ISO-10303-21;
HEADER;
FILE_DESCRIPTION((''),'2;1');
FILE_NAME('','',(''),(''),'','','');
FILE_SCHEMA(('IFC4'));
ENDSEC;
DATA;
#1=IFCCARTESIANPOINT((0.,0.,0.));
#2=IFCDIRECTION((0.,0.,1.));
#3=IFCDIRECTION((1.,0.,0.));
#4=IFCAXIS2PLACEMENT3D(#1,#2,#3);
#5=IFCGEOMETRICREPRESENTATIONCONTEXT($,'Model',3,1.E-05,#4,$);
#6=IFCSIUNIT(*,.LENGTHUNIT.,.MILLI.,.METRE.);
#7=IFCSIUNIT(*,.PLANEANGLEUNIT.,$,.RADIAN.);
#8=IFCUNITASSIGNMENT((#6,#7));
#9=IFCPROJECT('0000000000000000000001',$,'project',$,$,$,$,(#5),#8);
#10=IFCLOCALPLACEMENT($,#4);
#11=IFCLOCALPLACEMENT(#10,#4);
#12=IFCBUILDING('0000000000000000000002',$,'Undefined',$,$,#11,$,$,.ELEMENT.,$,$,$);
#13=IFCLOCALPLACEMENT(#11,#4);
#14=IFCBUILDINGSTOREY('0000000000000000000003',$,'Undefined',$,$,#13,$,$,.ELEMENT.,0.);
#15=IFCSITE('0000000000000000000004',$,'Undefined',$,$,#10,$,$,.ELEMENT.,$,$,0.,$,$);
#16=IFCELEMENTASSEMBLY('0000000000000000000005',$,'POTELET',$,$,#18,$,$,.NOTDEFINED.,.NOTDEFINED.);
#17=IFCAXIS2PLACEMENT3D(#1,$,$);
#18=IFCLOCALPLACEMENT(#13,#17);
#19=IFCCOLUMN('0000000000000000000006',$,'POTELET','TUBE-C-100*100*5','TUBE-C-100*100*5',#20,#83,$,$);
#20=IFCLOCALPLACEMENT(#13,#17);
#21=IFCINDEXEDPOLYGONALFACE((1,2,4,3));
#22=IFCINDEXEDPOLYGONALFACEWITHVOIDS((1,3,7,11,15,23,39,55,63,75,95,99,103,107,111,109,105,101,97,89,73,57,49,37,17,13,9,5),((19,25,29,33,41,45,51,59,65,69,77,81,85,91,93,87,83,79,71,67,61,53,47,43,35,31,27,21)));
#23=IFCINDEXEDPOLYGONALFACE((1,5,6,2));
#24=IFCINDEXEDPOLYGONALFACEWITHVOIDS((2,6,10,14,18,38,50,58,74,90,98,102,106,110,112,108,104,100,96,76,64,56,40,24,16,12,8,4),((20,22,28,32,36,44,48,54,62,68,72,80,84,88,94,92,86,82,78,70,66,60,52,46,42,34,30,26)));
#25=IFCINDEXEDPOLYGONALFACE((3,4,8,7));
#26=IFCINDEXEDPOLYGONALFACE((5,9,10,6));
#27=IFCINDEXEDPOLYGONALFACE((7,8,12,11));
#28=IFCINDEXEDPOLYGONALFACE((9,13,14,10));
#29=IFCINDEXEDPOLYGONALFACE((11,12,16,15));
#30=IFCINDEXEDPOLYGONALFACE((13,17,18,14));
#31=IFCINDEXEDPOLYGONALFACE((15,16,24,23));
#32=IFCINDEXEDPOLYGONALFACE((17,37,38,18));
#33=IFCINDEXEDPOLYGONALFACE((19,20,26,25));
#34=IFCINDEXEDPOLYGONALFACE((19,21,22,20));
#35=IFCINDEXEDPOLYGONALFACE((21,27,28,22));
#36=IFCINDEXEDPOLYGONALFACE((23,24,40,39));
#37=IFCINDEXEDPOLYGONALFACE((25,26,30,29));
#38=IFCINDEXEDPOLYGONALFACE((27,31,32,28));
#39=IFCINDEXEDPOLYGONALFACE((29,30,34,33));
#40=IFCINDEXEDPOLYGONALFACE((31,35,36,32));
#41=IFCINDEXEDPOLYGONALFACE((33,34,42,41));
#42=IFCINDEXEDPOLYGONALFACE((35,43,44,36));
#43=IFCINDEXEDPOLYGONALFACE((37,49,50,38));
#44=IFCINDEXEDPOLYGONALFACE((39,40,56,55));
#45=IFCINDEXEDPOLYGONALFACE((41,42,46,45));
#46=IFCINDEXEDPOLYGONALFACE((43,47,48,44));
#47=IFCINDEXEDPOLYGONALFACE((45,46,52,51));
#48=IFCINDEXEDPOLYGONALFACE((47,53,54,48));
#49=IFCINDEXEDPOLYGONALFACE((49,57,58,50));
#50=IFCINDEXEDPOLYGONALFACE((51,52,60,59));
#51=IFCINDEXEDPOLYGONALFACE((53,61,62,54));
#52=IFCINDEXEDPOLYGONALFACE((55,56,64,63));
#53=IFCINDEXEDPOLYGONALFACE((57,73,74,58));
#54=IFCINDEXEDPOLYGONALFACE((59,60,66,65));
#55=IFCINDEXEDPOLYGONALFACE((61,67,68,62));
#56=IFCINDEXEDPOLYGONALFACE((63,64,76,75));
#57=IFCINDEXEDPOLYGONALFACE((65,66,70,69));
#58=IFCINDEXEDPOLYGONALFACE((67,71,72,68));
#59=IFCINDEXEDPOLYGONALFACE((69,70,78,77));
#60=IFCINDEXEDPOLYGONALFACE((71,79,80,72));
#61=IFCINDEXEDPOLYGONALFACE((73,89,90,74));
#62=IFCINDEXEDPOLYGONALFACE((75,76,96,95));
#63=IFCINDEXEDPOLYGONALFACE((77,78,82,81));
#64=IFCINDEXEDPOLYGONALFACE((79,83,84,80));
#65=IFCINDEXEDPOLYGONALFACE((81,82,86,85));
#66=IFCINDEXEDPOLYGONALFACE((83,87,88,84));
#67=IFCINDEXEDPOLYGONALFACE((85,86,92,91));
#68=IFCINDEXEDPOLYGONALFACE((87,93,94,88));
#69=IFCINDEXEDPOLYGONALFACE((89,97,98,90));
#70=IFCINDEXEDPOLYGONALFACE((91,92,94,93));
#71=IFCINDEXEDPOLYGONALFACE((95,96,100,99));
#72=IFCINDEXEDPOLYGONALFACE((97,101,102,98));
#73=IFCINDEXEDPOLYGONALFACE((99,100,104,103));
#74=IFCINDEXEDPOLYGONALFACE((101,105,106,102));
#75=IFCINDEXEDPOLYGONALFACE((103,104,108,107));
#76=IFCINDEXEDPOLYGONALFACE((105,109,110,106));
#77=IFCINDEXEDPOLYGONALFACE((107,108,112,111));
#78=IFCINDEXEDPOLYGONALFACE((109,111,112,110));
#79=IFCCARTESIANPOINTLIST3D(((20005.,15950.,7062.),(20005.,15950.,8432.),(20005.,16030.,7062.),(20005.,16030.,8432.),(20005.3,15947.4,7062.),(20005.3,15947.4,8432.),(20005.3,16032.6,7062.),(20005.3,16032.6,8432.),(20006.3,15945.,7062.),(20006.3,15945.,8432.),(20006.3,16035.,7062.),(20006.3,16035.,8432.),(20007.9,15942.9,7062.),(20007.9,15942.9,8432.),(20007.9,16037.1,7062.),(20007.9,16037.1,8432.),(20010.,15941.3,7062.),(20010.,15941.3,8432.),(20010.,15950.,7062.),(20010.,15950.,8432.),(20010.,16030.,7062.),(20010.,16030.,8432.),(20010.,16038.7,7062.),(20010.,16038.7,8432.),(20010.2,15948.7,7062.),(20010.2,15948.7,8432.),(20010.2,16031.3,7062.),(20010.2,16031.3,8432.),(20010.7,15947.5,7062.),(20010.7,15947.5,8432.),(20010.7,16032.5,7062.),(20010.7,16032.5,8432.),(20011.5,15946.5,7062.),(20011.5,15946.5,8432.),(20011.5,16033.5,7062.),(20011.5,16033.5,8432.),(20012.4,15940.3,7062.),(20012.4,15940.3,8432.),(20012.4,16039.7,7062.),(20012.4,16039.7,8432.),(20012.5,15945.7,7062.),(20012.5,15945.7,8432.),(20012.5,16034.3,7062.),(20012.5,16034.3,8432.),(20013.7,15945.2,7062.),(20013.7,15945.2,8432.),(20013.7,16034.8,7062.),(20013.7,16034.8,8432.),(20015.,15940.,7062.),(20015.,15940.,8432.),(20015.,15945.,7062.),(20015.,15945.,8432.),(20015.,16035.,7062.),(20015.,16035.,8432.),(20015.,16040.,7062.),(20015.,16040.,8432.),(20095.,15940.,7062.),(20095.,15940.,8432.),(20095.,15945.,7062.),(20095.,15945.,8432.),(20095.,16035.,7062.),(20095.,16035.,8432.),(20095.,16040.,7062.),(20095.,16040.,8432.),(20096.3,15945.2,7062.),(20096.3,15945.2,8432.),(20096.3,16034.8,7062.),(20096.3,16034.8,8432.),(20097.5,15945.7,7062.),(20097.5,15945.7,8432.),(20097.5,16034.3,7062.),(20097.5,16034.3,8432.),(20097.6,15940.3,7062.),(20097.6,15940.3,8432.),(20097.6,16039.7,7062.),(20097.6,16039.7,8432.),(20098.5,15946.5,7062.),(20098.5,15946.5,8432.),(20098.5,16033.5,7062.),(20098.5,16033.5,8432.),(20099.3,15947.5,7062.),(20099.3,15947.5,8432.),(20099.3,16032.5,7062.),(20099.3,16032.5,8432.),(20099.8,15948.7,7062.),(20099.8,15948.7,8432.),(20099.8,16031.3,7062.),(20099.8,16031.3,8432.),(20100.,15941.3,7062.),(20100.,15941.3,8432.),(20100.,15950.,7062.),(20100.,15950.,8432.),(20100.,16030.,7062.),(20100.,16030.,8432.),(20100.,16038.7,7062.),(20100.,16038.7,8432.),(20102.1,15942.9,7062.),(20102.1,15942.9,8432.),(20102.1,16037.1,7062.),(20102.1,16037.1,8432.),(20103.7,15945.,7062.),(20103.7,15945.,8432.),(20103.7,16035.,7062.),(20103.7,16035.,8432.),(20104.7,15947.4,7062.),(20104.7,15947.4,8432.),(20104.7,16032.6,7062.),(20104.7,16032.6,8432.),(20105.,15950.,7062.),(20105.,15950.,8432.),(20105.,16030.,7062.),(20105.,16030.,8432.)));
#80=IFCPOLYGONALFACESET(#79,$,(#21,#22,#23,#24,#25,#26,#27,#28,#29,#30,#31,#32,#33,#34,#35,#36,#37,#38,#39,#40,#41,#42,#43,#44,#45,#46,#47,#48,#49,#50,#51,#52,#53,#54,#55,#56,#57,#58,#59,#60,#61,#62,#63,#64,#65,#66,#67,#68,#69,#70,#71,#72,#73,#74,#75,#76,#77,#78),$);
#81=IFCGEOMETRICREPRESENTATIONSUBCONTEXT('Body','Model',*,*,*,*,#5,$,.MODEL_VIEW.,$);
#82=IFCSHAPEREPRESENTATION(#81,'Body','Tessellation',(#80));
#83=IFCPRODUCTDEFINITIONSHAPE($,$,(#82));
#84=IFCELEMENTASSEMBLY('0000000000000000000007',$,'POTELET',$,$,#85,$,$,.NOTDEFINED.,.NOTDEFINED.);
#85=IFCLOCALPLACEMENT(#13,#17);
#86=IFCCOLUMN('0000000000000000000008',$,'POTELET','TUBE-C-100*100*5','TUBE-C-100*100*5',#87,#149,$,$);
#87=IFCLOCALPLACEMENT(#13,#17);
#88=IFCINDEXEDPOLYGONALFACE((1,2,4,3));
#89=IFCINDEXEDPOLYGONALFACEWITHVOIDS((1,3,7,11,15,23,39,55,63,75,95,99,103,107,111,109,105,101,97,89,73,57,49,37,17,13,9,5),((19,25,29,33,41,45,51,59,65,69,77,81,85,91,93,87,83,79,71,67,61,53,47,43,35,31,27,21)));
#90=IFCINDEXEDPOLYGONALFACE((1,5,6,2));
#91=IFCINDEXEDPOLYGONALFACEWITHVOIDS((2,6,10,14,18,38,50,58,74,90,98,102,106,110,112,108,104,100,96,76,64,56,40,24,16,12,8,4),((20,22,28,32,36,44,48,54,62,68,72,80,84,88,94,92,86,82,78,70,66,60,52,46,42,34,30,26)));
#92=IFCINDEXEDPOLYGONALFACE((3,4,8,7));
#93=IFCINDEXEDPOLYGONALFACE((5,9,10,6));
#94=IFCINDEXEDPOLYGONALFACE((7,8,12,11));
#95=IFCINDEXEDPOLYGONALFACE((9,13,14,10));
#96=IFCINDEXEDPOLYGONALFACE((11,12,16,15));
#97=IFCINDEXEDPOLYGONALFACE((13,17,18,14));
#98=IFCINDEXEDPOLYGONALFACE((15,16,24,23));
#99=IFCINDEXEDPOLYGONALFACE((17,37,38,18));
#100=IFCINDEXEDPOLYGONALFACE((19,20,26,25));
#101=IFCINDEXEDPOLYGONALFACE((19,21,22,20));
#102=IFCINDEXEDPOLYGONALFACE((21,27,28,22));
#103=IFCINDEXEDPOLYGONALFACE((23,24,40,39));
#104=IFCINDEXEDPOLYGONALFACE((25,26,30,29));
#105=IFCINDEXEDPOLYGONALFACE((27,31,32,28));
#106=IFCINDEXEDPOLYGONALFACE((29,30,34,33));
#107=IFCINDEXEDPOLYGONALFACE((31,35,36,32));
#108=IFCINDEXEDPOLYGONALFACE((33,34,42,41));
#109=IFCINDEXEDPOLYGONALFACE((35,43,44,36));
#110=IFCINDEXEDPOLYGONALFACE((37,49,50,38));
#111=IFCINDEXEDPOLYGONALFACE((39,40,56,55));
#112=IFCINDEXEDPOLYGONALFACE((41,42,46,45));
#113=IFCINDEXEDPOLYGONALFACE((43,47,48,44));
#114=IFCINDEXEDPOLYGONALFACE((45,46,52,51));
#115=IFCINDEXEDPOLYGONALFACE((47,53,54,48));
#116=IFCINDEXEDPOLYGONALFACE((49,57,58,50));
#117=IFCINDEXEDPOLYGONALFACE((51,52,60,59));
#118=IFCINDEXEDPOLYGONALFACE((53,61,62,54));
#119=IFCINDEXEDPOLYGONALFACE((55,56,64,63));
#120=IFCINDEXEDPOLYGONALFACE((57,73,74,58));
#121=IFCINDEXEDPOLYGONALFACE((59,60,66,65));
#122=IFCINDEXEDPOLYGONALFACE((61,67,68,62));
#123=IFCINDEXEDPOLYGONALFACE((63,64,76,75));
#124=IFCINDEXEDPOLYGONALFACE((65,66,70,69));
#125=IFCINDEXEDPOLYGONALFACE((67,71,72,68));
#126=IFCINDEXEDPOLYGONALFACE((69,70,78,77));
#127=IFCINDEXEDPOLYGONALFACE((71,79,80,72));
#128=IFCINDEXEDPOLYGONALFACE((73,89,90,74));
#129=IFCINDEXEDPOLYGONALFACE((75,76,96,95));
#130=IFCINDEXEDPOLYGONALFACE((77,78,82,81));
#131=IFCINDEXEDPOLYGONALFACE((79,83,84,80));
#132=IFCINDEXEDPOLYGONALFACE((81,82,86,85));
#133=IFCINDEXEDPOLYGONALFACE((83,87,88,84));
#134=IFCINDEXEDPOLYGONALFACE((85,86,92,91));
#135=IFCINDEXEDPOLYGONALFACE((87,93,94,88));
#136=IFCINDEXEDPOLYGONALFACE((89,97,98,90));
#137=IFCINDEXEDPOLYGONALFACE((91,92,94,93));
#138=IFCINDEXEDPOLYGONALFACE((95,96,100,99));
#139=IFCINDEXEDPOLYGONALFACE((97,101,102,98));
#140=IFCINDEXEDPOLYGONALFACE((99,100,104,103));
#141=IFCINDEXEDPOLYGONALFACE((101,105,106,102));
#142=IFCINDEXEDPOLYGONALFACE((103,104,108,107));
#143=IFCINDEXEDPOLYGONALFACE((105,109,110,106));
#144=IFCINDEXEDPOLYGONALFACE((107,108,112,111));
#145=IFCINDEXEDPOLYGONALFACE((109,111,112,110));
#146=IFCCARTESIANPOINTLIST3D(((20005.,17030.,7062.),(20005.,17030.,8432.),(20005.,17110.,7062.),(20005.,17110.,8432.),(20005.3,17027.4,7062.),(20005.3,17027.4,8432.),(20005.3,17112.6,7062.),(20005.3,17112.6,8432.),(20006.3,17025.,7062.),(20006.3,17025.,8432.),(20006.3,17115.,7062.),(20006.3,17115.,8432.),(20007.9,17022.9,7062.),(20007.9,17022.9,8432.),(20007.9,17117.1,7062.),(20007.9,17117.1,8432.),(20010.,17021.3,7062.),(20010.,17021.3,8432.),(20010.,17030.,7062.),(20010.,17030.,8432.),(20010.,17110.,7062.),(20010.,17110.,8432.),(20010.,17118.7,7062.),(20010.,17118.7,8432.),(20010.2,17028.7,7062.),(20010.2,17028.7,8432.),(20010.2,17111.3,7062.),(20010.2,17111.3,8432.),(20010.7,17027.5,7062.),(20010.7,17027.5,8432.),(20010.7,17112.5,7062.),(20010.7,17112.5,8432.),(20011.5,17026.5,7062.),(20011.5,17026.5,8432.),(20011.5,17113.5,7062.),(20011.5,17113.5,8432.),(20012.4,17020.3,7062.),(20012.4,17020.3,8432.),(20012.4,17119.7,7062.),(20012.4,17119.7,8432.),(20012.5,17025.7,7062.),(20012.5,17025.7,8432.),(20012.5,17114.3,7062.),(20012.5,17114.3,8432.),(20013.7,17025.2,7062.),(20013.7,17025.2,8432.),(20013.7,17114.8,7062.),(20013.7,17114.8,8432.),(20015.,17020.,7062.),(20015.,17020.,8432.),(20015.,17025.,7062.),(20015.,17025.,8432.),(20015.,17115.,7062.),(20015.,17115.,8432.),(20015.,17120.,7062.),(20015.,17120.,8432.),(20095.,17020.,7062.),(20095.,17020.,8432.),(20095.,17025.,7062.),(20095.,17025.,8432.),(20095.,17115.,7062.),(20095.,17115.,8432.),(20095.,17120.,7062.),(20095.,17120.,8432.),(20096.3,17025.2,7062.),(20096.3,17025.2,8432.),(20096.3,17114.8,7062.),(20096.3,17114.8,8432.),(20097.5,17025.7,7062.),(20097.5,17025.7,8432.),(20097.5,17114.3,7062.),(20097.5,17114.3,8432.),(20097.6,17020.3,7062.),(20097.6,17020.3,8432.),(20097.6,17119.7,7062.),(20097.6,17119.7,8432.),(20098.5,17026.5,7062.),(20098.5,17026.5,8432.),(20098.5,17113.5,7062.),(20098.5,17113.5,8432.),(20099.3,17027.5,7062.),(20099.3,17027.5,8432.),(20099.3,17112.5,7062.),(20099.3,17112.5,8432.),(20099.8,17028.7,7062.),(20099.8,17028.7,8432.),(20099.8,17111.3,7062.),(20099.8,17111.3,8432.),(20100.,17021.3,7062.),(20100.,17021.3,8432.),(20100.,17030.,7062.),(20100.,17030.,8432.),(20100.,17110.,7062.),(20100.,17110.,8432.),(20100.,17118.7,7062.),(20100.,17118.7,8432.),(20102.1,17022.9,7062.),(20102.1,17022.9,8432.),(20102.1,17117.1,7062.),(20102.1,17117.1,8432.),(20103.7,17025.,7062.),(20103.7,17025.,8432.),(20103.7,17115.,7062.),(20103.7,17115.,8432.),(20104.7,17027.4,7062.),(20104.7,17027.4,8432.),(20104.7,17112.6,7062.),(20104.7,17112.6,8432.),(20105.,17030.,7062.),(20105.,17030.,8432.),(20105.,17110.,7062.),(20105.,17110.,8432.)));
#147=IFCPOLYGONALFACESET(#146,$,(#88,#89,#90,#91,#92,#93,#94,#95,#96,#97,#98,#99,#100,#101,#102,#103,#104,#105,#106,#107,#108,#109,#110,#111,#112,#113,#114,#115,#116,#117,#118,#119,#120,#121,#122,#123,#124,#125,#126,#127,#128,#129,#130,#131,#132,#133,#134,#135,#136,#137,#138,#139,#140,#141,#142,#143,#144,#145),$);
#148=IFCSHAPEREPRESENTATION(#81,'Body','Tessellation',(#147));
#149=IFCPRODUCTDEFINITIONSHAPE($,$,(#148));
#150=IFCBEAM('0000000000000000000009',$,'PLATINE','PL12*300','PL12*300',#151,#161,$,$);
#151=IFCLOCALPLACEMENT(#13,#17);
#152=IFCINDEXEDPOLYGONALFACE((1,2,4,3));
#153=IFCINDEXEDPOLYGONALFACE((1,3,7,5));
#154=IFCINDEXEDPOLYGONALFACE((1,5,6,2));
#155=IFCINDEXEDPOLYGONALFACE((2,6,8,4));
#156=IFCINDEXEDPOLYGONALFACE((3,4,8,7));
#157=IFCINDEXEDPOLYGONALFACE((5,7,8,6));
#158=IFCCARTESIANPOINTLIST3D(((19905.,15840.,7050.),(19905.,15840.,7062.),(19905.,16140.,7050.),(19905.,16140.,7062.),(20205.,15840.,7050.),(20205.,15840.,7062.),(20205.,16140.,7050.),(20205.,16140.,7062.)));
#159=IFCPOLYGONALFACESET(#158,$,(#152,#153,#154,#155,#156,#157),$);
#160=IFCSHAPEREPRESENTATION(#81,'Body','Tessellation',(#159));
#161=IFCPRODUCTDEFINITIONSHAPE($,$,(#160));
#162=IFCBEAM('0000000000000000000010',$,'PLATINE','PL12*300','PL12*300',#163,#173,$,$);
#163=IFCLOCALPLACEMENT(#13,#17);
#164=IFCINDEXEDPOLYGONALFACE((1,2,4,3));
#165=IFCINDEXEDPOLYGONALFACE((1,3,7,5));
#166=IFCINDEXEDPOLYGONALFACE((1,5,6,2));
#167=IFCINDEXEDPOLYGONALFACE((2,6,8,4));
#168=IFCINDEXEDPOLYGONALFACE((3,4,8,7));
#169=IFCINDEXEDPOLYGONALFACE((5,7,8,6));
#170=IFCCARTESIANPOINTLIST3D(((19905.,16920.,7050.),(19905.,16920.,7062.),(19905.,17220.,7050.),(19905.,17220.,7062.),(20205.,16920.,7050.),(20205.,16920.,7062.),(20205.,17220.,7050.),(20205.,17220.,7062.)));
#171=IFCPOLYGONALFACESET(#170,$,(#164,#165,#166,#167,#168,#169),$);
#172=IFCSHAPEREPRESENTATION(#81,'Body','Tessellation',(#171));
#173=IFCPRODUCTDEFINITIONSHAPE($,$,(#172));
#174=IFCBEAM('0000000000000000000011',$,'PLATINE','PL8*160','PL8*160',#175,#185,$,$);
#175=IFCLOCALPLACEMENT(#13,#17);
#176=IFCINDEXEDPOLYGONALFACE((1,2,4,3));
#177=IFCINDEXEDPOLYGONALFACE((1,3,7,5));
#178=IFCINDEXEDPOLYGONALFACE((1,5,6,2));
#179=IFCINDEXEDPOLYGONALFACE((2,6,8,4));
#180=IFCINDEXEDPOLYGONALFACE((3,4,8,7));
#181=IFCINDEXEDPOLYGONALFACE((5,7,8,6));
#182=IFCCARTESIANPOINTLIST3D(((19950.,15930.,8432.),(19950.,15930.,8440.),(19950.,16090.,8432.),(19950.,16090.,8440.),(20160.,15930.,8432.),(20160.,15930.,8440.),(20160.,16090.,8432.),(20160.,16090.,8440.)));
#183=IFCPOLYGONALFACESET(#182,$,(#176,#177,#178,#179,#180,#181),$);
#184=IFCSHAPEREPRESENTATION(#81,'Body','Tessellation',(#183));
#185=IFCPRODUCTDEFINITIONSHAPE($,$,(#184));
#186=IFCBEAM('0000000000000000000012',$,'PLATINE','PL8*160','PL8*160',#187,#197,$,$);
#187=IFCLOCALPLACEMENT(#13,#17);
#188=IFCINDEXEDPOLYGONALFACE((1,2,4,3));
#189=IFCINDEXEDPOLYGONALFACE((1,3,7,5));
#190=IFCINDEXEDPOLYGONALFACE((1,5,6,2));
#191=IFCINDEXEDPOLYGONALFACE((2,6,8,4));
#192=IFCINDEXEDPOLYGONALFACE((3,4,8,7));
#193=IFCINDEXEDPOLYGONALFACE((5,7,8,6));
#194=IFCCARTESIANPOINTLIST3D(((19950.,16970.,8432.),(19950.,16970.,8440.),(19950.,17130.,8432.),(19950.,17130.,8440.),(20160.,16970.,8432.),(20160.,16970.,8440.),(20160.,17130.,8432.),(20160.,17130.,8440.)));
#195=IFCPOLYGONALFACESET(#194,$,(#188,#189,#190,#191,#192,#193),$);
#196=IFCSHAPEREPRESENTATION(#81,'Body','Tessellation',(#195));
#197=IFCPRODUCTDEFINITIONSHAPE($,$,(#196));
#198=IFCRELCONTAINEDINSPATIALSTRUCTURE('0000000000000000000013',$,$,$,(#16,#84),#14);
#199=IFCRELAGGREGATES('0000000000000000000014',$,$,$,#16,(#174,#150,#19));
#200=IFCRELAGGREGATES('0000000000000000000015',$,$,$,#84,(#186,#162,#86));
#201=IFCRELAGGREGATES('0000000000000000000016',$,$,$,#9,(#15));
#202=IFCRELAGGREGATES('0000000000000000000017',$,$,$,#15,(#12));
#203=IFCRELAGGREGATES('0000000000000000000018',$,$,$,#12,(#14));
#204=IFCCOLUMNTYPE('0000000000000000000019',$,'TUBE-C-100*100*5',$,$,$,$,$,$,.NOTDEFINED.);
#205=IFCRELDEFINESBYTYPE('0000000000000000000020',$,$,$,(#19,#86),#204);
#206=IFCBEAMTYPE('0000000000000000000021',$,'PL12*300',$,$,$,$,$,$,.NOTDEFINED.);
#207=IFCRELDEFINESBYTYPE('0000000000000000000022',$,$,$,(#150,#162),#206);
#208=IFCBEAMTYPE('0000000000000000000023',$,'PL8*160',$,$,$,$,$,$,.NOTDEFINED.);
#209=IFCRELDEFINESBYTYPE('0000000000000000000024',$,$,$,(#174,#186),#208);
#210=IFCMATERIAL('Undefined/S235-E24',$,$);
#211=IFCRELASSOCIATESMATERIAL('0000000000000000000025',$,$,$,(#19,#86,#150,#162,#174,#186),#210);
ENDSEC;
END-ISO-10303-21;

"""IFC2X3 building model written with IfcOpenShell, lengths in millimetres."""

from ifc_helpers import new_model, si_unit, frame, origin_with_axes, origin_2d_with_axis, place, context, subcontext, project, spatial, polyline, hollow_rectangle, outline, extrude, material, type_object, element, aggregate, save


model = new_model("IFC2X3")

# Units and contexts
model_context = context("Model", 3, precision=1e-05, world=origin_with_axes())
body_context = subcontext(model_context, "Body", "Model", "MODEL_VIEW")
ifc_project = project(units=[si_unit("LENGTHUNIT", "METRE", prefix="MILLI"), si_unit("PLANEANGLEUNIT", "RADIAN")], contexts=[model_context])

# Site, building, storey
site_placement = place(None, origin_with_axes())
site = spatial("IfcSite", under=ifc_project, at=site_placement, Name="Undefined", CompositionType="ELEMENT", RefElevation=0.0)
building_placement = place(site_placement, origin_with_axes())
building = spatial("IfcBuilding", under=site, at=building_placement, Name="Undefined", CompositionType="ELEMENT")
storey_placement = place(building_placement, origin_with_axes())
storey = spatial("IfcBuildingStorey", under=building, at=storey_placement, Name="Undefined", CompositionType="ELEMENT", Elevation=0.0)

# Element assemblies, columns
assembly_1_placement = place(storey_placement, origin_with_axes())
assembly_1 = element("IfcElementAssembly", 1, at=assembly_1_placement, inside=storey, Name="POTELET", AssemblyPlace="NOTDEFINED", PredefinedType="NOTDEFINED")
ifc_material_1 = material(Name="Undefined/S235-E24")
column_type = type_object("IfcColumnType", Name="TUBE-C-100*100*5", PredefinedType="NOTDEFINED")
column_1_placement = place(assembly_1_placement, frame((20055.0, 15990.0, 7062.0), z_axis=(0.0, 0.0, 1.0), x_axis=(0.0, 1.0, 0.0)))
column_1 = element("IfcColumn", 2, at=column_1_placement, type_object=column_type, material=ifc_material_1, Name="POTELET", Description="TUBE-C-100*100*5", ObjectType="TUBE-C-100*100*5", context=body_context, shape_type="SweptSolid", body=[
    extrude(hollow_rectangle(XDim=100.0, YDim=100.0, WallThickness=5.0, InnerFilletRadius=5.0, OuterFilletRadius=10.0, at=origin_2d_with_axis()), frame((0.0, 0.0, 1370.0), z_axis=(0.0, 0.0, -1.0), x_axis=(0.0, 1.0, 0.0)), (0.0, 0.0, 1.0), 1370.0),
])
assembly_2_placement = place(storey_placement, origin_with_axes())
assembly_2 = element("IfcElementAssembly", 3, at=assembly_2_placement, inside=storey, Name="POTELET", AssemblyPlace="NOTDEFINED", PredefinedType="NOTDEFINED")
column_2_placement = place(assembly_2_placement, frame((20055.0, 17070.0, 7062.0), z_axis=(0.0, 0.0, 1.0), x_axis=(0.0, -1.0, 0.0)))
column_2 = element("IfcColumn", 4, at=column_2_placement, type_object=column_type, material=ifc_material_1, Name="POTELET", Description="TUBE-C-100*100*5", ObjectType="TUBE-C-100*100*5", context=body_context, shape_type="SweptSolid", body=[
    extrude(hollow_rectangle(XDim=100.0, YDim=100.0, WallThickness=5.0, InnerFilletRadius=5.0, OuterFilletRadius=10.0, at=origin_2d_with_axis()), frame((0.0, 0.0, 1370.0), z_axis=(0.0, 0.0, -1.0), x_axis=(0.0, 1.0, 0.0)), (0.0, 0.0, 1.0), 1370.0),
])

# Beams
beam_type_1 = type_object("IfcBeamType", Name="PL12*300", PredefinedType="NOTDEFINED")
beam_1_placement = place(assembly_1_placement, frame((20205.0, 15840.0, 7056.0), z_axis=(0.0, 0.0, -1.0), x_axis=(-1.0, 0.0, 0.0)))
beam_1 = element("IfcBeam", 5, at=beam_1_placement, type_object=beam_type_1, material=ifc_material_1, Name="PLATINE", Description="PL12*300", ObjectType="PL12*300", context=body_context, shape_type="SweptSolid", body=[
    extrude(outline(polyline([(0.0, 0.0), (300.0, 0.0), (300.0, 300.0), (0.0, 300.0), (0.0, 0.0)])), frame((0.0, 0.0, -6.0), z_axis=(0.0, 0.0, 1.0), x_axis=(1.0, 0.0, 0.0)), (0.0, 0.0, 1.0), 12.0),
])
beam_2_placement = place(assembly_2_placement, frame((20205.0, 17220.0, 7056.0), z_axis=(0.0, 0.0, 1.0), x_axis=(-1.0, 0.0, 0.0)))
beam_2 = element("IfcBeam", 6, at=beam_2_placement, type_object=beam_type_1, material=ifc_material_1, Name="PLATINE", Description="PL12*300", ObjectType="PL12*300", context=body_context, shape_type="SweptSolid", body=[
    extrude(outline(polyline([(0.0, 0.0), (300.0, 0.0), (300.0, 300.0), (0.0, 300.0), (0.0, 0.0)])), frame((0.0, 0.0, -6.0), z_axis=(0.0, 0.0, 1.0), x_axis=(1.0, 0.0, 0.0)), (0.0, 0.0, 1.0), 12.0),
])
beam_type_2 = type_object("IfcBeamType", Name="PL8*160", PredefinedType="NOTDEFINED")
beam_3_placement = place(assembly_1_placement, frame((20160.0, 15930.0, 8436.0), z_axis=(0.0, 0.0, -1.0), x_axis=(-1.0, 0.0, 0.0)))
beam_3 = element("IfcBeam", 7, at=beam_3_placement, type_object=beam_type_2, material=ifc_material_1, Name="PLATINE", Description="PL8*160", ObjectType="PL8*160", context=body_context, shape_type="SweptSolid", body=[
    extrude(outline(polyline([(0.0, 0.0), (210.0, 0.0), (210.0, 160.0), (0.0, 160.0), (0.0, 0.0)])), frame((0.0, 0.0, -4.0), z_axis=(0.0, 0.0, 1.0), x_axis=(1.0, 0.0, 0.0)), (0.0, 0.0, 1.0), 8.0),
])
beam_4_placement = place(assembly_2_placement, frame((20160.0, 17130.0, 8436.0), z_axis=(0.0, 0.0, 1.0), x_axis=(-1.0, 0.0, 0.0)))
beam_4 = element("IfcBeam", 8, at=beam_4_placement, type_object=beam_type_2, material=ifc_material_1, Name="PLATINE", Description="PL8*160", ObjectType="PL8*160", context=body_context, shape_type="SweptSolid", body=[
    extrude(outline(polyline([(0.0, 0.0), (210.0, 0.0), (210.0, 160.0), (0.0, 160.0), (0.0, 0.0)])), frame((0.0, 0.0, -4.0), z_axis=(0.0, 0.0, 1.0), x_axis=(1.0, 0.0, 0.0)), (0.0, 0.0, 1.0), 8.0),
])

aggregate(assembly_1, [beam_3, beam_1, column_1])
aggregate(assembly_2, [beam_4, beam_2, column_2])

save(model, "model.ifc")
